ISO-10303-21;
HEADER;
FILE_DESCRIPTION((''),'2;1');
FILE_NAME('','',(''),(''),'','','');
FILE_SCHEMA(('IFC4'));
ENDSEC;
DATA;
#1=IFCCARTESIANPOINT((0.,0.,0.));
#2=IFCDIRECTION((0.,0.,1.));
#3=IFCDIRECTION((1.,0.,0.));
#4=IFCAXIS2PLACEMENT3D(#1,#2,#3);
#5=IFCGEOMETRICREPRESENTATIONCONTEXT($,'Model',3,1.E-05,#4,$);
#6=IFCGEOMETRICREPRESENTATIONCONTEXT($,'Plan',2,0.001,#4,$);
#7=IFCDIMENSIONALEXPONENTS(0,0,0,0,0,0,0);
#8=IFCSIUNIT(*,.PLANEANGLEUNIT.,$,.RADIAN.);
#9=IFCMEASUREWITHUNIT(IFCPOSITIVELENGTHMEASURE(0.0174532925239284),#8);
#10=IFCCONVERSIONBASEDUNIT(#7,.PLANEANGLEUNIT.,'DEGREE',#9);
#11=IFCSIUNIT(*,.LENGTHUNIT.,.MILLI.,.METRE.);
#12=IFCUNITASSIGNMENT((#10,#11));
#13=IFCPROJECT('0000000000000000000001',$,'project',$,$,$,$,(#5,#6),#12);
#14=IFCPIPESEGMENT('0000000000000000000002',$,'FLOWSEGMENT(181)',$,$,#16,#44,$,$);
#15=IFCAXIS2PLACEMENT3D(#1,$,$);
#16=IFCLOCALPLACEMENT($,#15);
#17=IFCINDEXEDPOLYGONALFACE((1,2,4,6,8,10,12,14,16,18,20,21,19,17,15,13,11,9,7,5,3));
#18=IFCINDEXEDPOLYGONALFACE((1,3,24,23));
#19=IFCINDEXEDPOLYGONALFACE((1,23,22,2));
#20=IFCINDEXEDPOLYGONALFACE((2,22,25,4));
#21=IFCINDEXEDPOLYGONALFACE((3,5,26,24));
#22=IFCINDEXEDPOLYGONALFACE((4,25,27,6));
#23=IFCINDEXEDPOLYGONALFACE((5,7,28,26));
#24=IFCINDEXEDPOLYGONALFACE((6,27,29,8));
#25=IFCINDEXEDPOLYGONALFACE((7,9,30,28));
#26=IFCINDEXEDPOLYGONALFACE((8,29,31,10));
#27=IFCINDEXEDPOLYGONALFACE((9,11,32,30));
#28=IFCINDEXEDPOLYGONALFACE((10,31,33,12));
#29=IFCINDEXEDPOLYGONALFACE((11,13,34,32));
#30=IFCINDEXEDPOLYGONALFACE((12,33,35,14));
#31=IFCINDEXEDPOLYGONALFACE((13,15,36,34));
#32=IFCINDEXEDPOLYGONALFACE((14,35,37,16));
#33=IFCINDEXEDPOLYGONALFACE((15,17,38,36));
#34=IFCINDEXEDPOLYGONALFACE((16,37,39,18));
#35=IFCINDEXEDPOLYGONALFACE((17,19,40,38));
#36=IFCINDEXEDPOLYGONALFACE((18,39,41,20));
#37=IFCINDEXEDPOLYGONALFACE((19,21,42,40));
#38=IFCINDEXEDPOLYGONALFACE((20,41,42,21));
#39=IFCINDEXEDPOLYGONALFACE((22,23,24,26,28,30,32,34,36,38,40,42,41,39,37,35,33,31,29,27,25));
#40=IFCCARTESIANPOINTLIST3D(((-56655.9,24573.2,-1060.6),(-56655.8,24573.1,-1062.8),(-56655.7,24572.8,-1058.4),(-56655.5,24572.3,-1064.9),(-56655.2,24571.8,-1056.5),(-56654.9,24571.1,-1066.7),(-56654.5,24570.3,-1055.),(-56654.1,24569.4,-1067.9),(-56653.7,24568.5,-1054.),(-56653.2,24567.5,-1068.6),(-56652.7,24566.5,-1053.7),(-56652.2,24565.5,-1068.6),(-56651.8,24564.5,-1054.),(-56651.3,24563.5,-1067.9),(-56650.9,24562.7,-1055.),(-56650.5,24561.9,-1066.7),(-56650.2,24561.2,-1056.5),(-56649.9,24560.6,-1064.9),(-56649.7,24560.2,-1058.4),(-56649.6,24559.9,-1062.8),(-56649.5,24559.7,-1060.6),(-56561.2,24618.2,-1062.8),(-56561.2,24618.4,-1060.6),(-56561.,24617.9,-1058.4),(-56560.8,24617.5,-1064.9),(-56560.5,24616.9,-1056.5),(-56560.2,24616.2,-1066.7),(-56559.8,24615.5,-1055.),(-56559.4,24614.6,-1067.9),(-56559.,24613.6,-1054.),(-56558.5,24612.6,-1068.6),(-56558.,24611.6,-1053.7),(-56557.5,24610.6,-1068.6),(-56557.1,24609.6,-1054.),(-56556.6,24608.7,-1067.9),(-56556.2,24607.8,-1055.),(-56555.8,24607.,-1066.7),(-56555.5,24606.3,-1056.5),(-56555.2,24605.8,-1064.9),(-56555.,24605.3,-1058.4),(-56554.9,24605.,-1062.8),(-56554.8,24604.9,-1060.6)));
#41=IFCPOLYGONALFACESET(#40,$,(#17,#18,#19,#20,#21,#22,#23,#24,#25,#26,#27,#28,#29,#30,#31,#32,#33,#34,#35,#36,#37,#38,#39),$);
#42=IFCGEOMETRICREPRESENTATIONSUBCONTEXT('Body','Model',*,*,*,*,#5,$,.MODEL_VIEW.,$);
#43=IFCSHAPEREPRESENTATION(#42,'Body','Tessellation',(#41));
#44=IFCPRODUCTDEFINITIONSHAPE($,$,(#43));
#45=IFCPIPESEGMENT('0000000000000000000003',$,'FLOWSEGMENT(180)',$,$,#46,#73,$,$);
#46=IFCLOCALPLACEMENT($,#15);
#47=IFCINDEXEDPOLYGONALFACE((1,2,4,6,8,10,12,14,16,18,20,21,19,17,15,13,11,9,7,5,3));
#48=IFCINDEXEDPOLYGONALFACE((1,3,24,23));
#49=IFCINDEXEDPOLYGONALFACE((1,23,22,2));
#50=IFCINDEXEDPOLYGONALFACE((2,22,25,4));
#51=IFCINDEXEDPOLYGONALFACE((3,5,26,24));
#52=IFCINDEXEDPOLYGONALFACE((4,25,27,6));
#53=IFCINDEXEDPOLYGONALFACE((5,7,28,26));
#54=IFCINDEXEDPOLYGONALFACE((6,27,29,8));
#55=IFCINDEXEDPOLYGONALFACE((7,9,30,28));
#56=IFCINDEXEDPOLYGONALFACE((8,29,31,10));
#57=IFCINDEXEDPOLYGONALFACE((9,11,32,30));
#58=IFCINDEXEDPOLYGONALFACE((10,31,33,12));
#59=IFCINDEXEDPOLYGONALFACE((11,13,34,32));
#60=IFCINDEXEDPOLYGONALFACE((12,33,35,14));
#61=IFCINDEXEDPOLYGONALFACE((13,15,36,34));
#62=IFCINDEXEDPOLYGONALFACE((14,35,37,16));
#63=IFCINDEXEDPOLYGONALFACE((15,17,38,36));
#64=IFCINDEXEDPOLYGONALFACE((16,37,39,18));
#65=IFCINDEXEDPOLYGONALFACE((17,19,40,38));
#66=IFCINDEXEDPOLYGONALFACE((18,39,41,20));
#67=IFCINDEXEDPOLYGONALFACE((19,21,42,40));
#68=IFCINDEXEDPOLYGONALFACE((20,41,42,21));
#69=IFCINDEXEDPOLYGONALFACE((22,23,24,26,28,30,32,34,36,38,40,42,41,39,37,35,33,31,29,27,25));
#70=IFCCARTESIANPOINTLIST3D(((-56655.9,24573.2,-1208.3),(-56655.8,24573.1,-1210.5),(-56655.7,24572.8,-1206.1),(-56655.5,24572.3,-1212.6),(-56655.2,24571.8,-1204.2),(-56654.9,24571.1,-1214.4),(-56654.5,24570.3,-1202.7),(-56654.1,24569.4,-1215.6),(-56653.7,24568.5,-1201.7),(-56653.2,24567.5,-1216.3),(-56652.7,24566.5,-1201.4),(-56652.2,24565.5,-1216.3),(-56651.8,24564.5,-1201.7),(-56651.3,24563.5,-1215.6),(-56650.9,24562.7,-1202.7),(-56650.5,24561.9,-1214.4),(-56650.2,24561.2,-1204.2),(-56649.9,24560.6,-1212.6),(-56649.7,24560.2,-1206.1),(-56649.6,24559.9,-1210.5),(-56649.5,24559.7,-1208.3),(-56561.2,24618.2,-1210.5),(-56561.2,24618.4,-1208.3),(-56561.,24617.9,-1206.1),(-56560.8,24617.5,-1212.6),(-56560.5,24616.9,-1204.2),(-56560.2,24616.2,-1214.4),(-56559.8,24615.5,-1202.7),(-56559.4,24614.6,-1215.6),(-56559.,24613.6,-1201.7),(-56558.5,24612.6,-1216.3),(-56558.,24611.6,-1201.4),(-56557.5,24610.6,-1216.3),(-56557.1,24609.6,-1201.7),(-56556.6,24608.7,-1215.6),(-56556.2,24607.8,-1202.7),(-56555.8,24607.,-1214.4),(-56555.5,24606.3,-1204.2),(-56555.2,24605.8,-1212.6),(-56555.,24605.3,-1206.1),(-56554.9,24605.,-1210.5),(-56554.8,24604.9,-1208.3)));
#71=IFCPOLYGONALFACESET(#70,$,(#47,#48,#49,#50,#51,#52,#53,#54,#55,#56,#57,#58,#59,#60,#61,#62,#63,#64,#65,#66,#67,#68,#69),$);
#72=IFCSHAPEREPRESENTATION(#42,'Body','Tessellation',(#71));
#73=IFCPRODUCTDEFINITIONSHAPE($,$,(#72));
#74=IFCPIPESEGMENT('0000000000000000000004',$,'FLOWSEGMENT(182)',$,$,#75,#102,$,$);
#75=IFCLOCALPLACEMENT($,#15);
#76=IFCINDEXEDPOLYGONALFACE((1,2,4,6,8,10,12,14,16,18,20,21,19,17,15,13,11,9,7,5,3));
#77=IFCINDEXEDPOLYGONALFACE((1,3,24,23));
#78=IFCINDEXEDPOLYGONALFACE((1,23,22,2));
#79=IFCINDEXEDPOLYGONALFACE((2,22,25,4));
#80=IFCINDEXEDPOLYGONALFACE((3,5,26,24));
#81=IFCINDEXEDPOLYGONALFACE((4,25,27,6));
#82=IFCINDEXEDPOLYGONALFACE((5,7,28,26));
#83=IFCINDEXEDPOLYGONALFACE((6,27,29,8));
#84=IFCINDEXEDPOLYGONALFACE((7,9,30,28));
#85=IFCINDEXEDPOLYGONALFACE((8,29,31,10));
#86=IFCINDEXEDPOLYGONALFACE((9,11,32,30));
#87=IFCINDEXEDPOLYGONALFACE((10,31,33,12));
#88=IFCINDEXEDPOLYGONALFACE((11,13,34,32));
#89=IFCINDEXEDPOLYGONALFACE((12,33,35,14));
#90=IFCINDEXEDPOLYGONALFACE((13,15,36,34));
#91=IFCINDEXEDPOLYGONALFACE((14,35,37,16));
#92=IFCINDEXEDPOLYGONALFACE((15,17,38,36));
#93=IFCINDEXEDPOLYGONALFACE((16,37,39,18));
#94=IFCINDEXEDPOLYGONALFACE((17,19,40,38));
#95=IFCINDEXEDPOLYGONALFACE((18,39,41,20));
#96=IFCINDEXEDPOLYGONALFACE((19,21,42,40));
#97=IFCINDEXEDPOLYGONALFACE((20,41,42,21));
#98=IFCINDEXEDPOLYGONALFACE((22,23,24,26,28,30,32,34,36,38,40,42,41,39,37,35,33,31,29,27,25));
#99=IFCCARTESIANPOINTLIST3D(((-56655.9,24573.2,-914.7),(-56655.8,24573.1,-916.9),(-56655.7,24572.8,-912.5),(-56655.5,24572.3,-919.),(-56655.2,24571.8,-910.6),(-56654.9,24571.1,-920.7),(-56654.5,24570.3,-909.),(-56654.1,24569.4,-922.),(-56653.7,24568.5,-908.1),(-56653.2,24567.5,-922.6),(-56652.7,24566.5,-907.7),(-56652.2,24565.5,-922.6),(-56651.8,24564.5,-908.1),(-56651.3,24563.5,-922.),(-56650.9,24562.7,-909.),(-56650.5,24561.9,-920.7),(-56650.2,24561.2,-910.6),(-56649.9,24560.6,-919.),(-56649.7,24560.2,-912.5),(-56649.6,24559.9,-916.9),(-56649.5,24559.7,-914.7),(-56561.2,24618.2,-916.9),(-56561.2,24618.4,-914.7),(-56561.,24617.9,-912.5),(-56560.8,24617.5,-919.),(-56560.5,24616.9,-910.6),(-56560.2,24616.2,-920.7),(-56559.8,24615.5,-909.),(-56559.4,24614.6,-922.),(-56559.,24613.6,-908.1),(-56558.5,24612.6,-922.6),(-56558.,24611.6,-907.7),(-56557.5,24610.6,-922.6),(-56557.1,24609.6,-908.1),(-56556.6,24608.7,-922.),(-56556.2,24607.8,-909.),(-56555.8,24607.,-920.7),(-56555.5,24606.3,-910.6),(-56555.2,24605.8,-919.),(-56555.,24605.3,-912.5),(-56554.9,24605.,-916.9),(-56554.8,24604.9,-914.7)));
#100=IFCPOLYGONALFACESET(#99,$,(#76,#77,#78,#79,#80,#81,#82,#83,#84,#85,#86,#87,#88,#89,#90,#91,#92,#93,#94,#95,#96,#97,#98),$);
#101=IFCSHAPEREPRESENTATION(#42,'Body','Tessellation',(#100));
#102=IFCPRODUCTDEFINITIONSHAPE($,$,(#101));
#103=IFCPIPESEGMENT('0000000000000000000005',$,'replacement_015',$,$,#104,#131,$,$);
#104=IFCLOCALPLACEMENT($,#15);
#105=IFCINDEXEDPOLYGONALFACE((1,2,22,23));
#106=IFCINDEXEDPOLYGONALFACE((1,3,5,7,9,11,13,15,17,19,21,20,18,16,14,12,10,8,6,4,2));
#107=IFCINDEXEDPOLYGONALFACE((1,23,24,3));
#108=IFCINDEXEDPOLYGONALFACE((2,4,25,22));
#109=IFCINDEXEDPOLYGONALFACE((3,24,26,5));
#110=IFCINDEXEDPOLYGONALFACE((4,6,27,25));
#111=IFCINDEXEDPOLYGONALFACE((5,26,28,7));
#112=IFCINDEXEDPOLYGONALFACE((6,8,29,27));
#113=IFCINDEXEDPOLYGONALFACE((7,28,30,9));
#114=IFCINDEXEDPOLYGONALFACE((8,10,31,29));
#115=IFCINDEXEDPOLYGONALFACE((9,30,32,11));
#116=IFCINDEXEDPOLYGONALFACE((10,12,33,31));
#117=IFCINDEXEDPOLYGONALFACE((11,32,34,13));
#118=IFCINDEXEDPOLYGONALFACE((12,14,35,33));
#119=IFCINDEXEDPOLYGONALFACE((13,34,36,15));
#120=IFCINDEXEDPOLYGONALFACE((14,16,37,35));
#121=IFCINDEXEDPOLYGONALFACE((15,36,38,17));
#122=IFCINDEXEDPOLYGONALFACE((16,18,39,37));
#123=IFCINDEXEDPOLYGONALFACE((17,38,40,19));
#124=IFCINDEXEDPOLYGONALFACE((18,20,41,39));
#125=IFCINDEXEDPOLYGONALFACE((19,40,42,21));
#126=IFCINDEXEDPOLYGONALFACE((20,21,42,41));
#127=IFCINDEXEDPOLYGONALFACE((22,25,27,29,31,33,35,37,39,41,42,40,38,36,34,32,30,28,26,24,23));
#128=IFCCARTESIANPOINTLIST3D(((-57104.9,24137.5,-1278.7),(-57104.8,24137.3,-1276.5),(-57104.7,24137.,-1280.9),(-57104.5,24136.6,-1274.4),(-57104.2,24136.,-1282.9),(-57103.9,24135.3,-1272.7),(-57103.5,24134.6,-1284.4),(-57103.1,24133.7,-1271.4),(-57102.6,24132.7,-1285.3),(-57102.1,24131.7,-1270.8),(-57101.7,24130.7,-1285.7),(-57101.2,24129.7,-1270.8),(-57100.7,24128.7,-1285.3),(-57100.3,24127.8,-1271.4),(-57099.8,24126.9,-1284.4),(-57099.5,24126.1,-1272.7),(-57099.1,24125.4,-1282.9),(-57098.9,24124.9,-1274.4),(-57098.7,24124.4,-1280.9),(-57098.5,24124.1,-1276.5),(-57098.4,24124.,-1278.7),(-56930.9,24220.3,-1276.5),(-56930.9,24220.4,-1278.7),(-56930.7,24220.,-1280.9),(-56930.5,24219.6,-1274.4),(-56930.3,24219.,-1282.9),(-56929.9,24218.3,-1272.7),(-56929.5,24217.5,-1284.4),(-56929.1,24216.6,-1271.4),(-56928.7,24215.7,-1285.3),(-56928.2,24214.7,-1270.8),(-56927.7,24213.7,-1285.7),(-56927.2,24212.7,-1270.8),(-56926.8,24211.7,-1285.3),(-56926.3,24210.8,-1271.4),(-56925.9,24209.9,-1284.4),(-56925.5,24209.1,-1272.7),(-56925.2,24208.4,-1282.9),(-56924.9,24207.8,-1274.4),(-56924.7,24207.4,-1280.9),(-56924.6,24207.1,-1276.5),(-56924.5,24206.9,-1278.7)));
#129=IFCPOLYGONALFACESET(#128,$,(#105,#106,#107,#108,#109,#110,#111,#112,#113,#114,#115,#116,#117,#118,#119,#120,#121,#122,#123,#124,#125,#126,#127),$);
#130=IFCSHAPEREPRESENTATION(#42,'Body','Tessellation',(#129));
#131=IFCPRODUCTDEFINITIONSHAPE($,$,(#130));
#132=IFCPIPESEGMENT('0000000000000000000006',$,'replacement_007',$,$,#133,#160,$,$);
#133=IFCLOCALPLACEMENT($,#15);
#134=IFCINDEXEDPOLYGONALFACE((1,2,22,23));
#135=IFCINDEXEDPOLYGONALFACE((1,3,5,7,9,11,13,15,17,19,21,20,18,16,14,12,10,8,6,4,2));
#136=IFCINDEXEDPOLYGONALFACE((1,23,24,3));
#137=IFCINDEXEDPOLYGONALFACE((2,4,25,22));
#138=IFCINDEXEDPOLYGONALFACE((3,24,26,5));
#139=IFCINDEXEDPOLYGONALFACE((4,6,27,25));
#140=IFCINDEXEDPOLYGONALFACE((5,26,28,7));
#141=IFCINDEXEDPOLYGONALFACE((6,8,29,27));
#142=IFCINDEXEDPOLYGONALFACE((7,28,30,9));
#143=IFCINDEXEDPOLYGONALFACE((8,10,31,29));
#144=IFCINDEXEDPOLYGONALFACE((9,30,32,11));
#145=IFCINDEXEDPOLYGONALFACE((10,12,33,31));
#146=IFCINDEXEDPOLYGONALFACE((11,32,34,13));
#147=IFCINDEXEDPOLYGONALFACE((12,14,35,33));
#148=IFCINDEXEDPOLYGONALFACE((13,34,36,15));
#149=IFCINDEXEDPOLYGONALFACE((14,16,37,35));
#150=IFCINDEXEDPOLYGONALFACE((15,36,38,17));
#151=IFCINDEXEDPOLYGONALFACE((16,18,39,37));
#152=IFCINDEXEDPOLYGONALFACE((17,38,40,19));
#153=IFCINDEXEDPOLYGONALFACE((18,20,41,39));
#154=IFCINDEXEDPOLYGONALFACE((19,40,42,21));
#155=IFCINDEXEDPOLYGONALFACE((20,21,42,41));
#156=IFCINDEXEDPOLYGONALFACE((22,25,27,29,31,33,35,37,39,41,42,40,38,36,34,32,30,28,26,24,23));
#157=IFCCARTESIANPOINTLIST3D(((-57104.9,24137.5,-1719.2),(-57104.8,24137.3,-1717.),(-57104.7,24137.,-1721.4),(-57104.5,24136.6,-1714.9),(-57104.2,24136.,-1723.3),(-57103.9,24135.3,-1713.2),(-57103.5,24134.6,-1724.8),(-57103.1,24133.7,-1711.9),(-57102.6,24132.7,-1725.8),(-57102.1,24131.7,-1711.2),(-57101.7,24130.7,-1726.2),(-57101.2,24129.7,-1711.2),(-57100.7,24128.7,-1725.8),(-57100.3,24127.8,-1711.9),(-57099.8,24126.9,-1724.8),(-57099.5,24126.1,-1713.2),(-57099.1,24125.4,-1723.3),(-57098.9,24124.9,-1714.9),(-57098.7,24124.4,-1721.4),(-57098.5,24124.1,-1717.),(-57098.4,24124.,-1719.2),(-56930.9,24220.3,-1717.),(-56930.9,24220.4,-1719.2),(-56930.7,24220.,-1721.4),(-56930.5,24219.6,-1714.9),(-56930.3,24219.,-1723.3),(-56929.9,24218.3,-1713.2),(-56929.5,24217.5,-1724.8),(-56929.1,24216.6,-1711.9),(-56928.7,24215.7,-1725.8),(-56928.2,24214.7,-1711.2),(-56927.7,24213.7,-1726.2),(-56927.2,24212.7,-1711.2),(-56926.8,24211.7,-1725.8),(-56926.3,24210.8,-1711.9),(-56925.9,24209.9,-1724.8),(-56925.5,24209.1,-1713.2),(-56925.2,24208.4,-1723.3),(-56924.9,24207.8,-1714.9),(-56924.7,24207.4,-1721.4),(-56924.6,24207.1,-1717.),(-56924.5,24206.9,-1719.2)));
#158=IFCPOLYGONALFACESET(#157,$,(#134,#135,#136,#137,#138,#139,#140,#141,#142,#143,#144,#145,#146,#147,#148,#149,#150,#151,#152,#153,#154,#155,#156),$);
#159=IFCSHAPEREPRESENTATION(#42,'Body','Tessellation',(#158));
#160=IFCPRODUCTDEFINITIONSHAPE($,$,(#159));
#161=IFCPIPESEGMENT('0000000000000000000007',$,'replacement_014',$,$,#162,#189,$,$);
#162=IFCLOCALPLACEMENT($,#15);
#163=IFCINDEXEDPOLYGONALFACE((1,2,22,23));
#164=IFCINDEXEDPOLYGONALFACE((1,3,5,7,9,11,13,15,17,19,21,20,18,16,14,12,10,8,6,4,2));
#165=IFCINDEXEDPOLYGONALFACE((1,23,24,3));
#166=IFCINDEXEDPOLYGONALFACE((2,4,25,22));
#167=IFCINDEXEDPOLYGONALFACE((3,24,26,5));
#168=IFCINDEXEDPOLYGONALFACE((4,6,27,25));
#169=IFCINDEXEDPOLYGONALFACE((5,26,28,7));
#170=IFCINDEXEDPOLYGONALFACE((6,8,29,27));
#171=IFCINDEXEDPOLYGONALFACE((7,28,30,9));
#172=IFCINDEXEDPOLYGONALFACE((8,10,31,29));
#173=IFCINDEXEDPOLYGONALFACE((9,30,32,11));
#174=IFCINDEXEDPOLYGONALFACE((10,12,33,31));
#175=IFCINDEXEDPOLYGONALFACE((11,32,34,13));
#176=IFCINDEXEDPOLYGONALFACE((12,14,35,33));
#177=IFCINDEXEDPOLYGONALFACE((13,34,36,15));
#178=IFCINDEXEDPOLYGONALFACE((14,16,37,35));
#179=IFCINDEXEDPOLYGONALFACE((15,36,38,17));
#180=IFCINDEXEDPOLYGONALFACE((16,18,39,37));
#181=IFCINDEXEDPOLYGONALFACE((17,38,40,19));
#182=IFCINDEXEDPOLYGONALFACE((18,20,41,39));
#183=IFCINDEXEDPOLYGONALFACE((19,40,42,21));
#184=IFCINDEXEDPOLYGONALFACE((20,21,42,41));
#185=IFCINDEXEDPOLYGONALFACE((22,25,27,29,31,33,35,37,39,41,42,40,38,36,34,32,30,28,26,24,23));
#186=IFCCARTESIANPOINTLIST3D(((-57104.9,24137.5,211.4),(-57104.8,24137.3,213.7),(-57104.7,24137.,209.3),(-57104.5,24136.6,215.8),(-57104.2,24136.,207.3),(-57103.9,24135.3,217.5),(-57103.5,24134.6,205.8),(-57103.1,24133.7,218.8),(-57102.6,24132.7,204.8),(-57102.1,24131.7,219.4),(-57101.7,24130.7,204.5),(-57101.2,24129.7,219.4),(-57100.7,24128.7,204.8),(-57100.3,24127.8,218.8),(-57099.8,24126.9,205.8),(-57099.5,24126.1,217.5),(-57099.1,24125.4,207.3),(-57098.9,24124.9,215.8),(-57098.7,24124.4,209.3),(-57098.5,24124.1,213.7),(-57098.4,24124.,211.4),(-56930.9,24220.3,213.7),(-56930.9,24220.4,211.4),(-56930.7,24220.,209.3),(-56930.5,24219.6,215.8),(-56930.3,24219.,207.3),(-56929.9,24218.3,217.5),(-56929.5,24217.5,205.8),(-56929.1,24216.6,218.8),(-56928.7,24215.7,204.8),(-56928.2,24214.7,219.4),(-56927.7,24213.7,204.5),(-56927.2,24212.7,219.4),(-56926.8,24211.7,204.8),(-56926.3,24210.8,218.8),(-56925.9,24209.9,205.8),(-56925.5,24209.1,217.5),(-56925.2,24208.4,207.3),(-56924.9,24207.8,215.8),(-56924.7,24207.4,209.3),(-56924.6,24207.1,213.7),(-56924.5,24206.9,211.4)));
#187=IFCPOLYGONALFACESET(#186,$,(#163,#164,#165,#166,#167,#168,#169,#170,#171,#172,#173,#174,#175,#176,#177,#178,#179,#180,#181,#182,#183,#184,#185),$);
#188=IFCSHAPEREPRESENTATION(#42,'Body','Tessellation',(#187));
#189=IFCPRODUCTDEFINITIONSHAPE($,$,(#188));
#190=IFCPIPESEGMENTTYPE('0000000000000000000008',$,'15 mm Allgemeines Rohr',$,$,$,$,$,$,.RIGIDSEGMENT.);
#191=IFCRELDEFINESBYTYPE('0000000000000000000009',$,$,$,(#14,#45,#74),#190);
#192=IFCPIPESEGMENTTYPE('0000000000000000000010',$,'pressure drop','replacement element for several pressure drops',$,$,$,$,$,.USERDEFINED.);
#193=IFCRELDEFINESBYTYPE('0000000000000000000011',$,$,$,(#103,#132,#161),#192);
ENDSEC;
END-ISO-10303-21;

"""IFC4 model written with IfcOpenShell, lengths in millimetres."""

from ifc_helpers import new_model, entity, si_unit, converted_unit, frame, frame_2d, origin, origin_with_axes, place, context, subcontext, project, circle, extrude, source, transform, mapped, type_object, element, save


model = new_model("IFC4")

# Units and contexts
model_context = context("Model", 3, precision=1e-05, world=origin_with_axes())
plan_context = context("Plan", 2, precision=0.001, world=origin_with_axes())
body_context = subcontext(model_context, "Body", "Model", "MODEL_VIEW")
ifc_project = project(units=[converted_unit("PLANEANGLEUNIT", "DEGREE", entity("IfcPositiveLengthMeasure", 0.0174532925239284), si_unit("PLANEANGLEUNIT", "RADIAN"), dimensions=[0, 0, 0, 0, 0, 0, 0]), si_unit("LENGTHUNIT", "METRE", prefix="MILLI")], contexts=[model_context, plan_context])

# Pipe segments
pipe_segment_type_1 = type_object("IfcPipeSegmentType", Name="15 mm Allgemeines Rohr", PredefinedType="RIGIDSEGMENT")
shared_shape = source(origin(), body_context, "Body", "SweptSolid", [
    extrude(circle(Radius=7.5, at=frame_2d((7.5, 7.5), x_axis=(1.0, 0.0))), frame((0.0, -7.5, -7.5), z_axis=(1.0, 0.0, 0.0), x_axis=(0.0, 1.0, 0.0)), (0.0, 0.0, 1.0), 1.0),
])
placement_1 = place(None, origin_with_axes())
placement_2 = place(placement_1, origin_with_axes())
placement_3 = place(placement_2, frame((0.0, 0.0, -3400.0), z_axis=(0.0, 0.0, 1.0), x_axis=(1.0, 0.0, 0.0)))
for number, where, z_axis, x_axis, name in (
    (1, (-56558.0, 24611.6, 2338.8), (-0.430461, 0.902609, 0.0), (-0.902609, -0.430461, 0.0), "FLOWSEGMENT(181)"),
    (2, (-56558.0, 24611.6, 2191.1), (-0.430461, 0.902609, 0.0), (-0.902609, -0.430461, 0.0), "FLOWSEGMENT(180)"),
    (3, (-56558.0, 24611.6, 2484.8), (-0.430461, 0.902609, 0.0), (-0.902609, -0.430461, 0.0), "FLOWSEGMENT(182)"),
):
    element("IfcPipeSegment", number, at=place(placement_3, frame(where, z_axis=z_axis, x_axis=x_axis)), type_object=pipe_segment_type_1, Name=name, context=body_context, shape_type="MappedRepresentation", body=[
        mapped(shared_shape, transform((0.0, 0.0, 0.0), x_axis=(1.0, 0.0, 0.0), y_axis=(0.0, 1.0, 0.0), z_axis=(0.0, 0.0, 1.0), scale=104.898581, scale2=1.0, scale3=1.0, uniform=False)),
    ])
pipe_segment_type_2 = type_object("IfcPipeSegmentType", Name="pressure drop", Description="replacement element for several pressure drops", PredefinedType="USERDEFINED")
for number, where, z_axis, x_axis, name in (
    (4, (-57101.7, 24130.7, 2121.8), (-0.430461, 0.902609, 0.0), (0.902609, 0.430461, 0.0), "replacement_015"),
    (5, (-57101.7, 24130.7, 1681.3), (-0.430461, 0.902609, 0.0), (0.902609, 0.430461, 0.0), "replacement_007"),
):
    element("IfcPipeSegment", number, at=place(placement_3, frame(where, z_axis=z_axis, x_axis=x_axis)), type_object=pipe_segment_type_2, Name=name, context=body_context, shape_type="MappedRepresentation", body=[
        mapped(shared_shape, transform((0.0, 0.0, 0.0), x_axis=(1.0, 0.0, 0.0), y_axis=(0.0, 1.0, 0.0), z_axis=(0.0, 0.0, 1.0), scale=192.697716, scale2=1.0, scale3=1.0, uniform=False)),
    ])
for number, where, z_axis, x_axis, name in (
    (6, (-57101.7, 24130.7, 3612.0), (-0.430461, 0.902609, 0.0), (0.902609, 0.430461, 0.0), "replacement_014"),
):
    element("IfcPipeSegment", number, at=place(placement_3, frame(where, z_axis=z_axis, x_axis=x_axis)), type_object=pipe_segment_type_2, Name=name, context=body_context, shape_type="MappedRepresentation", body=[
        mapped(shared_shape, transform((0.0, 0.0, 0.0), x_axis=(1.0, 0.0, 0.0), y_axis=(0.0, 1.0, 0.0), z_axis=(0.0, 0.0, 1.0), scale=192.697716, scale2=1.0, scale3=1.0, uniform=False)),
    ])

save(model, "model.ifc")
